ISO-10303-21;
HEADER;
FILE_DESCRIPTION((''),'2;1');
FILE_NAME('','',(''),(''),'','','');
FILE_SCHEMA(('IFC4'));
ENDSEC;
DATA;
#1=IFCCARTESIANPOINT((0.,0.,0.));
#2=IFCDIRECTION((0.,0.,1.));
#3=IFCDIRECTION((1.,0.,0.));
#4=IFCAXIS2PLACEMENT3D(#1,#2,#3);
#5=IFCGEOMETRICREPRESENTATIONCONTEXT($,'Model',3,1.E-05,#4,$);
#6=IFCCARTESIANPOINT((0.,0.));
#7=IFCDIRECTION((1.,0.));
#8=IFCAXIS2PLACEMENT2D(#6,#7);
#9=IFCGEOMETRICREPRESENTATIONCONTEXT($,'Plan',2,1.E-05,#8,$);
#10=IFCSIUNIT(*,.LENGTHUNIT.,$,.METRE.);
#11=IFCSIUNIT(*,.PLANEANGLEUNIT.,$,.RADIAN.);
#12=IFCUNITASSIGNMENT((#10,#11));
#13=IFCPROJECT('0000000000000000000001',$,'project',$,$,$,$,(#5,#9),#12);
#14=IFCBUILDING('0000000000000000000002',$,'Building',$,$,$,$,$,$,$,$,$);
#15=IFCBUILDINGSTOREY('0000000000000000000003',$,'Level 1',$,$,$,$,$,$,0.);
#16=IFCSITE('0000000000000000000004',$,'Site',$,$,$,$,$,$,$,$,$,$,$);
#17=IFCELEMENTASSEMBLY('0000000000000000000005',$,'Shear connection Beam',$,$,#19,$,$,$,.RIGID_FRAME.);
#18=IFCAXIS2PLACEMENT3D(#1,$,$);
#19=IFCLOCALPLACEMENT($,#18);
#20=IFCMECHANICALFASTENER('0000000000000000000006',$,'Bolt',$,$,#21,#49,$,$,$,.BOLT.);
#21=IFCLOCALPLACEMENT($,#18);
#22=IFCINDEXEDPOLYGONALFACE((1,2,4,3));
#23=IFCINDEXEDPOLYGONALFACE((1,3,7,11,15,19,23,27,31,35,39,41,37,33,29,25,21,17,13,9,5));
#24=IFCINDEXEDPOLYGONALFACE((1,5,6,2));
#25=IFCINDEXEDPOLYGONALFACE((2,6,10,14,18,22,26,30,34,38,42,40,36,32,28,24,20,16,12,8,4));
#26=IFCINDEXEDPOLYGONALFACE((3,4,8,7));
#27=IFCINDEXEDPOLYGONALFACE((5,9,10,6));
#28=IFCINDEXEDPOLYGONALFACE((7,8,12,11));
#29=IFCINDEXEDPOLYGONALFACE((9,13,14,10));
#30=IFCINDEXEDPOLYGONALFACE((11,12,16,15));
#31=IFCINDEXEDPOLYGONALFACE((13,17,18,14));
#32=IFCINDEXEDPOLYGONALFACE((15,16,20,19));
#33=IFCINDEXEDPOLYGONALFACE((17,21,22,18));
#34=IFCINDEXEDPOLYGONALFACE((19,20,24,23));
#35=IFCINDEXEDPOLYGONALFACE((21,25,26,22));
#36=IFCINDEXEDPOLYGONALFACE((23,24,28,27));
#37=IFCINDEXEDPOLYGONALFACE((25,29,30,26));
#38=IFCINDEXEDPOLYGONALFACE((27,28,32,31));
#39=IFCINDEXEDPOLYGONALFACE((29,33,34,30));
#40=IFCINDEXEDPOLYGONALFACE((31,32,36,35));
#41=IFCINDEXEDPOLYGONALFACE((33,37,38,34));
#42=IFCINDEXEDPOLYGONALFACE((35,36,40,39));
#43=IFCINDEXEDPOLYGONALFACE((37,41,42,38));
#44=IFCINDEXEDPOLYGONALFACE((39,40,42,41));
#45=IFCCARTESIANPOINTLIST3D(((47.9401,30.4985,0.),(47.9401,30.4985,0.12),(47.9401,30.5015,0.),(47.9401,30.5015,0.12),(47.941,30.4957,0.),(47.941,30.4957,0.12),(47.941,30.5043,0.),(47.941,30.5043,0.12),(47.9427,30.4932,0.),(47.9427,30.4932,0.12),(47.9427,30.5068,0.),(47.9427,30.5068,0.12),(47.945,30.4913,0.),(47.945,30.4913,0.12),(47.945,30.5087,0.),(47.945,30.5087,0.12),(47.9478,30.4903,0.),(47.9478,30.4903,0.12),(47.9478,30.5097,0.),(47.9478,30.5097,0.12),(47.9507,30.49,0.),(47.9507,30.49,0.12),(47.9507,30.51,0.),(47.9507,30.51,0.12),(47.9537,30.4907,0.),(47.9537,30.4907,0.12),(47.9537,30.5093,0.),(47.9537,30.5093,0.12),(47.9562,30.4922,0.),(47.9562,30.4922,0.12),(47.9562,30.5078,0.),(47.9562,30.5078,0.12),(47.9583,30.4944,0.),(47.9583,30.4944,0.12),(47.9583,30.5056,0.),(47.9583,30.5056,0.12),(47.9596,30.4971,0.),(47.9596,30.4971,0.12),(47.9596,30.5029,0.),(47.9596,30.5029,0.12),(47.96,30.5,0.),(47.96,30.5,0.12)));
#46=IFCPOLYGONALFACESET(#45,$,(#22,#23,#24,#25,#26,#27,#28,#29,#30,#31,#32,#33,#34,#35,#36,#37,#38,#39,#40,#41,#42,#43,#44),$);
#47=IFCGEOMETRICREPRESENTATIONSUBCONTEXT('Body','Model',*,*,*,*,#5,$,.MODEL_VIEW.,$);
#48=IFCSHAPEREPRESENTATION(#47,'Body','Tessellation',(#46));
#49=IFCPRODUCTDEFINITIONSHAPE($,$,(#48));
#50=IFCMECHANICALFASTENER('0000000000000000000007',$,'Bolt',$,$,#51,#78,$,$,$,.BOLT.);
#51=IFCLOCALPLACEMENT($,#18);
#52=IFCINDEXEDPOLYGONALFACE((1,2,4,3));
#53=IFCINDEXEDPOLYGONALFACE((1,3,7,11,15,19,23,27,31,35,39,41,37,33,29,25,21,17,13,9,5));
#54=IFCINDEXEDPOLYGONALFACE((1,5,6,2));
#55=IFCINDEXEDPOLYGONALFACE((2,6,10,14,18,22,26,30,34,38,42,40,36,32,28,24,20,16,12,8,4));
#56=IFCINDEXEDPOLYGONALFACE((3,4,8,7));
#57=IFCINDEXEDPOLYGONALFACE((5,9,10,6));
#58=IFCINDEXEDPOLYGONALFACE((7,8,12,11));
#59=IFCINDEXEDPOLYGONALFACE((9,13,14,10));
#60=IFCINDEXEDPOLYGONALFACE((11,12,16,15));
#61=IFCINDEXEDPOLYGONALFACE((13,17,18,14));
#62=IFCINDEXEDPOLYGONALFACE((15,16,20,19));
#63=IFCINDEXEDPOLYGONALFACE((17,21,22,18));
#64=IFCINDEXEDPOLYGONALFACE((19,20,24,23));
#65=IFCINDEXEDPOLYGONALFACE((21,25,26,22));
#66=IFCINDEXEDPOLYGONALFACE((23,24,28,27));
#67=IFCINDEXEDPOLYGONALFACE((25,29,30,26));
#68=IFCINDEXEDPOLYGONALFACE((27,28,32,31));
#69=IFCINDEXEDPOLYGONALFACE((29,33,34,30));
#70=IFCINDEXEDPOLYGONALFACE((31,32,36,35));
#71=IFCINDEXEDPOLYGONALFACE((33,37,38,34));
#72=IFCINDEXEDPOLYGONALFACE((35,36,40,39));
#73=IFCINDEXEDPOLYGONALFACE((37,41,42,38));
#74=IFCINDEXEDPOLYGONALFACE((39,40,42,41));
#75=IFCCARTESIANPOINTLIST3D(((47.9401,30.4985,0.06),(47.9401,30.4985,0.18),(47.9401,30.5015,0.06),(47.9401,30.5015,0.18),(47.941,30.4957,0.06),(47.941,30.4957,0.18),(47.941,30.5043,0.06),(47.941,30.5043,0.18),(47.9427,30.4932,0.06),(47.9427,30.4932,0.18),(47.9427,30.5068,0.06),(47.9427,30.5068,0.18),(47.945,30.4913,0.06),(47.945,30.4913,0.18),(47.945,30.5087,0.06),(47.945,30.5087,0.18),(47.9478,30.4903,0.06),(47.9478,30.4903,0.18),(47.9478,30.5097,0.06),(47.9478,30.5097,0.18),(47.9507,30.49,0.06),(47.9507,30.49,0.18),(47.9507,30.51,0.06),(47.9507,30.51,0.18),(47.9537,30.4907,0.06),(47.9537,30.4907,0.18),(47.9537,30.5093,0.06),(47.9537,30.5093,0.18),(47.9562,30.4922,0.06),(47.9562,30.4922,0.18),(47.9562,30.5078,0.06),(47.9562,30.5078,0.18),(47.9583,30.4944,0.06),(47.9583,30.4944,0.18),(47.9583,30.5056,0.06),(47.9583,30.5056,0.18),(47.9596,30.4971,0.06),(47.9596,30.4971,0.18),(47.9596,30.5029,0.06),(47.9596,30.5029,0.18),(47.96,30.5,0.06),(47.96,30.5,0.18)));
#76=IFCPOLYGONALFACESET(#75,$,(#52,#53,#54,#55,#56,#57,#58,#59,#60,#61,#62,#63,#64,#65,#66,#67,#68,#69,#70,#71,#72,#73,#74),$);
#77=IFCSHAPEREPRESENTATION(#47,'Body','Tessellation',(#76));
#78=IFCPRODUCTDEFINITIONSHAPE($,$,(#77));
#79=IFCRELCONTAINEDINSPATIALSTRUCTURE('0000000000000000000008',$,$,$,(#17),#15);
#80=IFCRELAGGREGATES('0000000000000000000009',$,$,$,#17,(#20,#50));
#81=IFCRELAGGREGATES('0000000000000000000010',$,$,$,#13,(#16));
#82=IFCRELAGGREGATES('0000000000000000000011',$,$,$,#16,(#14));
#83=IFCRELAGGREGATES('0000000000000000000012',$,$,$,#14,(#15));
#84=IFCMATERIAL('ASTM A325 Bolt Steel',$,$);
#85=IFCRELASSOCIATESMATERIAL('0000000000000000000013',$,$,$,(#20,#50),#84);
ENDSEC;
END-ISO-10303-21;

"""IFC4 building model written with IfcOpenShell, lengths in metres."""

from ifc_helpers import new_model, si_unit, frame, origin_with_axes, origin_2d, origin_2d_with_axis, place, context, subcontext, project, spatial, circle, extrude, material, element, aggregate, save


model = new_model("IFC4")

# Units and contexts
model_context = context("Model", 3, precision=1e-05, world=origin_with_axes())
plan_context = context("Plan", 2, precision=1e-05, world=origin_2d_with_axis())
body_context = subcontext(model_context, "Body", "Model", "MODEL_VIEW")
ifc_project = project(units=[si_unit("LENGTHUNIT", "METRE"), si_unit("PLANEANGLEUNIT", "RADIAN")], contexts=[model_context, plan_context])

# Site, building, storey
site = spatial("IfcSite", under=ifc_project, Name="Site")
building = spatial("IfcBuilding", under=site, Name="Building")
storey = spatial("IfcBuildingStorey", under=building, Name="Level 1", Elevation=0.0)

# Element assembly
assembly_1 = element("IfcElementAssembly", 1, inside=storey, Name="Shear connection Beam", PredefinedType="RIGID_FRAME")

# Shared definitions
ifc_material_1 = material(Name="ASTM A325 Bolt Steel")

# Mechanical fasteners
mechanical_fastener_1_placement = place(None, frame((47.95, 30.5, 0.0), z_axis=(0.0, 0.0, 1.0), x_axis=(1.0, 0.0, 0.0)))
mechanical_fastener_1 = element("IfcMechanicalFastener", 2, at=mechanical_fastener_1_placement, material=ifc_material_1, Name="Bolt", PredefinedType="BOLT", context=body_context, shape_type="SweptSolid", body=[
    extrude(circle(Radius=0.01, at=origin_2d()), origin_with_axes(), (0.0, 0.0, 1.0), 0.12),
])
mechanical_fastener_2_placement = place(None, frame((47.95, 30.5, 0.06), z_axis=(0.0, 0.0, 1.0), x_axis=(1.0, 0.0, 0.0)))
mechanical_fastener_2 = element("IfcMechanicalFastener", 3, at=mechanical_fastener_2_placement, material=ifc_material_1, Name="Bolt", PredefinedType="BOLT", context=body_context, shape_type="SweptSolid", body=[
    extrude(circle(Radius=0.01, at=origin_2d()), origin_with_axes(), (0.0, 0.0, 1.0), 0.12),
])
aggregate(assembly_1, [mechanical_fastener_1, mechanical_fastener_2])

save(model, "model.ifc")
